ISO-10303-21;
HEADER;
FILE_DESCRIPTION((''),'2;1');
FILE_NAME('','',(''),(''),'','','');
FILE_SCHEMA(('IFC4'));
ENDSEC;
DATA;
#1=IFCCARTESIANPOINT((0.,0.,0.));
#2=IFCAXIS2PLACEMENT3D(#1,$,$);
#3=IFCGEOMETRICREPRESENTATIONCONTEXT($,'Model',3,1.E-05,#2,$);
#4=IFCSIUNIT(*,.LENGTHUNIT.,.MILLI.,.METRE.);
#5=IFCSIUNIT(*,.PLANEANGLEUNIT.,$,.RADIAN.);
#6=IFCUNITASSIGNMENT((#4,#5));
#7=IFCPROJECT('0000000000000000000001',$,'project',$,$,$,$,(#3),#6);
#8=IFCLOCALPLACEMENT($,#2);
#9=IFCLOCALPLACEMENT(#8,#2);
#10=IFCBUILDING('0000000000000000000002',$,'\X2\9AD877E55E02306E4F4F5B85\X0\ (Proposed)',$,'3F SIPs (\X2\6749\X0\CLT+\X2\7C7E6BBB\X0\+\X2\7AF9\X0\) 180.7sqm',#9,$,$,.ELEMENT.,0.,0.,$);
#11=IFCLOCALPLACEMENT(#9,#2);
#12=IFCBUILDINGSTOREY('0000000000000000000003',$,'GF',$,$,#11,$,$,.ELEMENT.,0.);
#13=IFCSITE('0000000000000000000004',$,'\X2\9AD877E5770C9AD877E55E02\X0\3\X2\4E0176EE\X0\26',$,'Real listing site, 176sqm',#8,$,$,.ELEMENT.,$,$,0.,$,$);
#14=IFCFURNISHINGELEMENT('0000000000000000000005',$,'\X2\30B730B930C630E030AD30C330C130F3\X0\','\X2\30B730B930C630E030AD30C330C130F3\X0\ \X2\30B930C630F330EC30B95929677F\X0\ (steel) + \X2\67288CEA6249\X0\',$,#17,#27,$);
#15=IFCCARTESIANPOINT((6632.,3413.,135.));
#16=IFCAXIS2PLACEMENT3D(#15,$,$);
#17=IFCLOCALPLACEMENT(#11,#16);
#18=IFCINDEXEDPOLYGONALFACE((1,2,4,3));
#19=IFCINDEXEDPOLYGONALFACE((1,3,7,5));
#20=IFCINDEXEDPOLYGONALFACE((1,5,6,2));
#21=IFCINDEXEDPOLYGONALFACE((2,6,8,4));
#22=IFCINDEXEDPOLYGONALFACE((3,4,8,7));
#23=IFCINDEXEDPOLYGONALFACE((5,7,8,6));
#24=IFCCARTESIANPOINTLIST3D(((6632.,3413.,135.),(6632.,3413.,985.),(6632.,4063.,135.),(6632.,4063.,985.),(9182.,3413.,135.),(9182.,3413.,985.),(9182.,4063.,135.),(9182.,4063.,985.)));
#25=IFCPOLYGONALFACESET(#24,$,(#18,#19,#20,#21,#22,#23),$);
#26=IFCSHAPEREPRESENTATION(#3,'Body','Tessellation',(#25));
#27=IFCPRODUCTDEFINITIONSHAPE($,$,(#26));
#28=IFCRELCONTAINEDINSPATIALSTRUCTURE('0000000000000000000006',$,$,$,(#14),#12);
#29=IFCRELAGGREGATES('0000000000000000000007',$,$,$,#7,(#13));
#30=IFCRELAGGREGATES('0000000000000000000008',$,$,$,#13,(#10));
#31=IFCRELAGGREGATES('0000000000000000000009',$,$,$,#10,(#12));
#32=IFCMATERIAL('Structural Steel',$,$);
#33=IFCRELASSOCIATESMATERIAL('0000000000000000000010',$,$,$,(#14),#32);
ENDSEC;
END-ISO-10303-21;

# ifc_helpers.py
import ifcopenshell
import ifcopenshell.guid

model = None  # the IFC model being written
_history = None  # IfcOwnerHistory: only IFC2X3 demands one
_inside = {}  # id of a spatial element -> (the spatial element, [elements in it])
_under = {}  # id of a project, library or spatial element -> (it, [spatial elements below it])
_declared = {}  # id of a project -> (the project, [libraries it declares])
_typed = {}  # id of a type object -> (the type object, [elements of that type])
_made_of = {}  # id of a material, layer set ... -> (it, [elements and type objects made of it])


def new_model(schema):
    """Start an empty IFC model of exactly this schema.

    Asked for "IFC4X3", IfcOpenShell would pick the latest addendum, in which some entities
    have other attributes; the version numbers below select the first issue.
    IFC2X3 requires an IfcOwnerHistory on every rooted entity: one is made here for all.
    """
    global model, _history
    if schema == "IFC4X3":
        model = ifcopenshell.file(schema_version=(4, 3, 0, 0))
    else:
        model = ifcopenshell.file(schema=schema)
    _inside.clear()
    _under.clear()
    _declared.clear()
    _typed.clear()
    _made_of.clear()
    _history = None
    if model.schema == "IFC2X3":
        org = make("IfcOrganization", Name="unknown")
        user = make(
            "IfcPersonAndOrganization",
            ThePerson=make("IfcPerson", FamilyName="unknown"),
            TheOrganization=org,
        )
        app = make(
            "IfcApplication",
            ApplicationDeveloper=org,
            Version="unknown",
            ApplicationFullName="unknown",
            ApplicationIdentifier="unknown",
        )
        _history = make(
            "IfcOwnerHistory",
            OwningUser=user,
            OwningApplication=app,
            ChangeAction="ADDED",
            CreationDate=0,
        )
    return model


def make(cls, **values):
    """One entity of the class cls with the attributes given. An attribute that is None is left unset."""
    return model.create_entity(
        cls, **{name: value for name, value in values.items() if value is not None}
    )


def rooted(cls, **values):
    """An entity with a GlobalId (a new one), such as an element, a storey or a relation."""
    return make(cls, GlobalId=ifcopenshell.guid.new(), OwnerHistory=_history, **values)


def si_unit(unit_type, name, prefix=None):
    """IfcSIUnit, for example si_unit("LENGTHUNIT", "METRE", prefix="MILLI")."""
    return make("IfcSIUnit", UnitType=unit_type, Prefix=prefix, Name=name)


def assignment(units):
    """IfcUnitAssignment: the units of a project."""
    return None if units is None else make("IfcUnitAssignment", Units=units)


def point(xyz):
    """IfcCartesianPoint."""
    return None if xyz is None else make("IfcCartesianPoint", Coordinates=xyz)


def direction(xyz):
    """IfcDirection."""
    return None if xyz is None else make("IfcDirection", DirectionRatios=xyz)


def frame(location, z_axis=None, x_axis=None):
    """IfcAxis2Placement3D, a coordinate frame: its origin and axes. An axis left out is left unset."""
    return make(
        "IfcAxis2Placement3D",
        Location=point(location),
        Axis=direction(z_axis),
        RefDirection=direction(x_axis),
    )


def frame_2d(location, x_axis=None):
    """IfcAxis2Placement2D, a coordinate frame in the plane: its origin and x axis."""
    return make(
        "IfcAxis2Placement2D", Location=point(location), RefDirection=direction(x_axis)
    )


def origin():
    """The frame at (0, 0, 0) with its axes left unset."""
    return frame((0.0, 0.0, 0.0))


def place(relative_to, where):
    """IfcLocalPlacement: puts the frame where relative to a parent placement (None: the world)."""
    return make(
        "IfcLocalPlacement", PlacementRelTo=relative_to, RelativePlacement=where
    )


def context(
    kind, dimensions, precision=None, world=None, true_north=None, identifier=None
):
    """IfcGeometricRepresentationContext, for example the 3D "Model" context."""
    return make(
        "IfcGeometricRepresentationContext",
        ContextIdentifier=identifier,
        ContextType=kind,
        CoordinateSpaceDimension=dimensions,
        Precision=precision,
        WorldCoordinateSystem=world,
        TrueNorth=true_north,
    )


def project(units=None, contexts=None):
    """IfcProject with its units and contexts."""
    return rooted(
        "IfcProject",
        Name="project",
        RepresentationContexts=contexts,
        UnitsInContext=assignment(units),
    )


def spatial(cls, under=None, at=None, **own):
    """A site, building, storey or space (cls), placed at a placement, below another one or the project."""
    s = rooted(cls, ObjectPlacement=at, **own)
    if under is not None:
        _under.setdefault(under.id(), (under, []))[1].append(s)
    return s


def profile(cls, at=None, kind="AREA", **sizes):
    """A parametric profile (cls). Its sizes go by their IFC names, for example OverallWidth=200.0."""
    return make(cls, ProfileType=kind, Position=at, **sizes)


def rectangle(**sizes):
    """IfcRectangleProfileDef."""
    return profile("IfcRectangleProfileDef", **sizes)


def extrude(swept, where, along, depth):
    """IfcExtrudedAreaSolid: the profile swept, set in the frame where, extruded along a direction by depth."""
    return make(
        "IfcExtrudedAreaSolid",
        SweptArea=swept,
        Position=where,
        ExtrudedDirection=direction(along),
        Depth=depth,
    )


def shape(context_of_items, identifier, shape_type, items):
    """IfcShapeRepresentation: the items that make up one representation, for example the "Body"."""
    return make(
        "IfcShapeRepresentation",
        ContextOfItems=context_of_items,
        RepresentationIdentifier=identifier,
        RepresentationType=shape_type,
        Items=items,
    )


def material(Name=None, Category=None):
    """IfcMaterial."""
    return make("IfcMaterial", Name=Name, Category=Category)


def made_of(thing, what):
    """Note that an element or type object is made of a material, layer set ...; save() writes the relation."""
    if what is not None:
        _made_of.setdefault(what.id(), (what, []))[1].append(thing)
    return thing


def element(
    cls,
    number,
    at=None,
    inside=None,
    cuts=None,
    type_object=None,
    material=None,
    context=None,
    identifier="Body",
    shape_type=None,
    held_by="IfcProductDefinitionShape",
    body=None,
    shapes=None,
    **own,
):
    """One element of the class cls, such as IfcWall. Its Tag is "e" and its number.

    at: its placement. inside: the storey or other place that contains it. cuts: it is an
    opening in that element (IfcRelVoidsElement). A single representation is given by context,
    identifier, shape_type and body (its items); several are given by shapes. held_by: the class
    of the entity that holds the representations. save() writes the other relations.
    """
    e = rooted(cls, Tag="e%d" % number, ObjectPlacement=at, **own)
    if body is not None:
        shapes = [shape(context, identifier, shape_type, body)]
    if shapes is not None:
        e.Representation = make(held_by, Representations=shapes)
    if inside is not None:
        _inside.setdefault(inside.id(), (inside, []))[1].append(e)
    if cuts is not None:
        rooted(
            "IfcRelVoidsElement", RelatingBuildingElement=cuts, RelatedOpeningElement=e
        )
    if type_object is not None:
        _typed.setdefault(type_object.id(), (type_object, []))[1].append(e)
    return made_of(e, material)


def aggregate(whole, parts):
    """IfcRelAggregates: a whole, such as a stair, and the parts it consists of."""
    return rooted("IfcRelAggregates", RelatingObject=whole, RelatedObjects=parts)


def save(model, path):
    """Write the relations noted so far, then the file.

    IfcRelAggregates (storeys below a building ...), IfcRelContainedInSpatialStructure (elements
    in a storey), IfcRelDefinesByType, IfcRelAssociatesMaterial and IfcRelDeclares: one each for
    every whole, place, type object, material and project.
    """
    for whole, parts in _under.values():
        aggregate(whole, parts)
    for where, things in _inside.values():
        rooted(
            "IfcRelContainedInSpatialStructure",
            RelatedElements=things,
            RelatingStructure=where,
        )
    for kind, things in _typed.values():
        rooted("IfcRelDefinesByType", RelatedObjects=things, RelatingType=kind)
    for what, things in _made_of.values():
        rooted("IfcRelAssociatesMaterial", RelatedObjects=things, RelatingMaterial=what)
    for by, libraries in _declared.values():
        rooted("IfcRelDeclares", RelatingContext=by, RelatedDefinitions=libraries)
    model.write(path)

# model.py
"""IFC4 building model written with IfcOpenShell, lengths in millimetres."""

from ifc_helpers import new_model, si_unit, frame, frame_2d, origin, place, context, project, spatial, rectangle, extrude, material, element, save


model = new_model("IFC4")

# Units and contexts
model_context = context("Model", 3, precision=1e-05, world=origin())
ifc_project = project(units=[si_unit("LENGTHUNIT", "METRE", prefix="MILLI"), si_unit("PLANEANGLEUNIT", "RADIAN")], contexts=[model_context])

# Site, building, storey
site_placement = place(None, origin())
site = spatial("IfcSite", under=ifc_project, at=site_placement, Name="高知県高知市3丁目26", ObjectType="Real listing site, 176sqm", CompositionType="ELEMENT", RefElevation=0.0)
building_placement = place(site_placement, origin())
building = spatial("IfcBuilding", under=site, at=building_placement, Name="高知市の住宅 (Proposed)", ObjectType="3F SIPs (杉CLT+籾殻+竹) 180.7sqm", CompositionType="ELEMENT", ElevationOfRefHeight=0.0, ElevationOfTerrain=0.0)
storey_placement = place(building_placement, origin())
storey = spatial("IfcBuildingStorey", under=building, at=storey_placement, Name="GF", CompositionType="ELEMENT", Elevation=0.0)

# Furnishing element
ifc_material_1 = material(Name="Structural Steel")
furnishing_1_placement = place(storey_placement, frame((6632.0, 3413.0, 135.0)))
element("IfcFurnishingElement", 1, at=furnishing_1_placement, inside=storey, material=ifc_material_1, Name="システムキッチン", Description="システムキッチン ステンレス天板 (steel) + 木質扉", context=model_context, shape_type="SweptSolid", body=[
    extrude(rectangle(XDim=2550.0, YDim=650.0, at=frame_2d((1275.0, 325.0))), frame((6632.0, 3413.0, 135.0)), (0.0, 0.0, 1.0), 850.0),
])

save(model, "model.ifc")
